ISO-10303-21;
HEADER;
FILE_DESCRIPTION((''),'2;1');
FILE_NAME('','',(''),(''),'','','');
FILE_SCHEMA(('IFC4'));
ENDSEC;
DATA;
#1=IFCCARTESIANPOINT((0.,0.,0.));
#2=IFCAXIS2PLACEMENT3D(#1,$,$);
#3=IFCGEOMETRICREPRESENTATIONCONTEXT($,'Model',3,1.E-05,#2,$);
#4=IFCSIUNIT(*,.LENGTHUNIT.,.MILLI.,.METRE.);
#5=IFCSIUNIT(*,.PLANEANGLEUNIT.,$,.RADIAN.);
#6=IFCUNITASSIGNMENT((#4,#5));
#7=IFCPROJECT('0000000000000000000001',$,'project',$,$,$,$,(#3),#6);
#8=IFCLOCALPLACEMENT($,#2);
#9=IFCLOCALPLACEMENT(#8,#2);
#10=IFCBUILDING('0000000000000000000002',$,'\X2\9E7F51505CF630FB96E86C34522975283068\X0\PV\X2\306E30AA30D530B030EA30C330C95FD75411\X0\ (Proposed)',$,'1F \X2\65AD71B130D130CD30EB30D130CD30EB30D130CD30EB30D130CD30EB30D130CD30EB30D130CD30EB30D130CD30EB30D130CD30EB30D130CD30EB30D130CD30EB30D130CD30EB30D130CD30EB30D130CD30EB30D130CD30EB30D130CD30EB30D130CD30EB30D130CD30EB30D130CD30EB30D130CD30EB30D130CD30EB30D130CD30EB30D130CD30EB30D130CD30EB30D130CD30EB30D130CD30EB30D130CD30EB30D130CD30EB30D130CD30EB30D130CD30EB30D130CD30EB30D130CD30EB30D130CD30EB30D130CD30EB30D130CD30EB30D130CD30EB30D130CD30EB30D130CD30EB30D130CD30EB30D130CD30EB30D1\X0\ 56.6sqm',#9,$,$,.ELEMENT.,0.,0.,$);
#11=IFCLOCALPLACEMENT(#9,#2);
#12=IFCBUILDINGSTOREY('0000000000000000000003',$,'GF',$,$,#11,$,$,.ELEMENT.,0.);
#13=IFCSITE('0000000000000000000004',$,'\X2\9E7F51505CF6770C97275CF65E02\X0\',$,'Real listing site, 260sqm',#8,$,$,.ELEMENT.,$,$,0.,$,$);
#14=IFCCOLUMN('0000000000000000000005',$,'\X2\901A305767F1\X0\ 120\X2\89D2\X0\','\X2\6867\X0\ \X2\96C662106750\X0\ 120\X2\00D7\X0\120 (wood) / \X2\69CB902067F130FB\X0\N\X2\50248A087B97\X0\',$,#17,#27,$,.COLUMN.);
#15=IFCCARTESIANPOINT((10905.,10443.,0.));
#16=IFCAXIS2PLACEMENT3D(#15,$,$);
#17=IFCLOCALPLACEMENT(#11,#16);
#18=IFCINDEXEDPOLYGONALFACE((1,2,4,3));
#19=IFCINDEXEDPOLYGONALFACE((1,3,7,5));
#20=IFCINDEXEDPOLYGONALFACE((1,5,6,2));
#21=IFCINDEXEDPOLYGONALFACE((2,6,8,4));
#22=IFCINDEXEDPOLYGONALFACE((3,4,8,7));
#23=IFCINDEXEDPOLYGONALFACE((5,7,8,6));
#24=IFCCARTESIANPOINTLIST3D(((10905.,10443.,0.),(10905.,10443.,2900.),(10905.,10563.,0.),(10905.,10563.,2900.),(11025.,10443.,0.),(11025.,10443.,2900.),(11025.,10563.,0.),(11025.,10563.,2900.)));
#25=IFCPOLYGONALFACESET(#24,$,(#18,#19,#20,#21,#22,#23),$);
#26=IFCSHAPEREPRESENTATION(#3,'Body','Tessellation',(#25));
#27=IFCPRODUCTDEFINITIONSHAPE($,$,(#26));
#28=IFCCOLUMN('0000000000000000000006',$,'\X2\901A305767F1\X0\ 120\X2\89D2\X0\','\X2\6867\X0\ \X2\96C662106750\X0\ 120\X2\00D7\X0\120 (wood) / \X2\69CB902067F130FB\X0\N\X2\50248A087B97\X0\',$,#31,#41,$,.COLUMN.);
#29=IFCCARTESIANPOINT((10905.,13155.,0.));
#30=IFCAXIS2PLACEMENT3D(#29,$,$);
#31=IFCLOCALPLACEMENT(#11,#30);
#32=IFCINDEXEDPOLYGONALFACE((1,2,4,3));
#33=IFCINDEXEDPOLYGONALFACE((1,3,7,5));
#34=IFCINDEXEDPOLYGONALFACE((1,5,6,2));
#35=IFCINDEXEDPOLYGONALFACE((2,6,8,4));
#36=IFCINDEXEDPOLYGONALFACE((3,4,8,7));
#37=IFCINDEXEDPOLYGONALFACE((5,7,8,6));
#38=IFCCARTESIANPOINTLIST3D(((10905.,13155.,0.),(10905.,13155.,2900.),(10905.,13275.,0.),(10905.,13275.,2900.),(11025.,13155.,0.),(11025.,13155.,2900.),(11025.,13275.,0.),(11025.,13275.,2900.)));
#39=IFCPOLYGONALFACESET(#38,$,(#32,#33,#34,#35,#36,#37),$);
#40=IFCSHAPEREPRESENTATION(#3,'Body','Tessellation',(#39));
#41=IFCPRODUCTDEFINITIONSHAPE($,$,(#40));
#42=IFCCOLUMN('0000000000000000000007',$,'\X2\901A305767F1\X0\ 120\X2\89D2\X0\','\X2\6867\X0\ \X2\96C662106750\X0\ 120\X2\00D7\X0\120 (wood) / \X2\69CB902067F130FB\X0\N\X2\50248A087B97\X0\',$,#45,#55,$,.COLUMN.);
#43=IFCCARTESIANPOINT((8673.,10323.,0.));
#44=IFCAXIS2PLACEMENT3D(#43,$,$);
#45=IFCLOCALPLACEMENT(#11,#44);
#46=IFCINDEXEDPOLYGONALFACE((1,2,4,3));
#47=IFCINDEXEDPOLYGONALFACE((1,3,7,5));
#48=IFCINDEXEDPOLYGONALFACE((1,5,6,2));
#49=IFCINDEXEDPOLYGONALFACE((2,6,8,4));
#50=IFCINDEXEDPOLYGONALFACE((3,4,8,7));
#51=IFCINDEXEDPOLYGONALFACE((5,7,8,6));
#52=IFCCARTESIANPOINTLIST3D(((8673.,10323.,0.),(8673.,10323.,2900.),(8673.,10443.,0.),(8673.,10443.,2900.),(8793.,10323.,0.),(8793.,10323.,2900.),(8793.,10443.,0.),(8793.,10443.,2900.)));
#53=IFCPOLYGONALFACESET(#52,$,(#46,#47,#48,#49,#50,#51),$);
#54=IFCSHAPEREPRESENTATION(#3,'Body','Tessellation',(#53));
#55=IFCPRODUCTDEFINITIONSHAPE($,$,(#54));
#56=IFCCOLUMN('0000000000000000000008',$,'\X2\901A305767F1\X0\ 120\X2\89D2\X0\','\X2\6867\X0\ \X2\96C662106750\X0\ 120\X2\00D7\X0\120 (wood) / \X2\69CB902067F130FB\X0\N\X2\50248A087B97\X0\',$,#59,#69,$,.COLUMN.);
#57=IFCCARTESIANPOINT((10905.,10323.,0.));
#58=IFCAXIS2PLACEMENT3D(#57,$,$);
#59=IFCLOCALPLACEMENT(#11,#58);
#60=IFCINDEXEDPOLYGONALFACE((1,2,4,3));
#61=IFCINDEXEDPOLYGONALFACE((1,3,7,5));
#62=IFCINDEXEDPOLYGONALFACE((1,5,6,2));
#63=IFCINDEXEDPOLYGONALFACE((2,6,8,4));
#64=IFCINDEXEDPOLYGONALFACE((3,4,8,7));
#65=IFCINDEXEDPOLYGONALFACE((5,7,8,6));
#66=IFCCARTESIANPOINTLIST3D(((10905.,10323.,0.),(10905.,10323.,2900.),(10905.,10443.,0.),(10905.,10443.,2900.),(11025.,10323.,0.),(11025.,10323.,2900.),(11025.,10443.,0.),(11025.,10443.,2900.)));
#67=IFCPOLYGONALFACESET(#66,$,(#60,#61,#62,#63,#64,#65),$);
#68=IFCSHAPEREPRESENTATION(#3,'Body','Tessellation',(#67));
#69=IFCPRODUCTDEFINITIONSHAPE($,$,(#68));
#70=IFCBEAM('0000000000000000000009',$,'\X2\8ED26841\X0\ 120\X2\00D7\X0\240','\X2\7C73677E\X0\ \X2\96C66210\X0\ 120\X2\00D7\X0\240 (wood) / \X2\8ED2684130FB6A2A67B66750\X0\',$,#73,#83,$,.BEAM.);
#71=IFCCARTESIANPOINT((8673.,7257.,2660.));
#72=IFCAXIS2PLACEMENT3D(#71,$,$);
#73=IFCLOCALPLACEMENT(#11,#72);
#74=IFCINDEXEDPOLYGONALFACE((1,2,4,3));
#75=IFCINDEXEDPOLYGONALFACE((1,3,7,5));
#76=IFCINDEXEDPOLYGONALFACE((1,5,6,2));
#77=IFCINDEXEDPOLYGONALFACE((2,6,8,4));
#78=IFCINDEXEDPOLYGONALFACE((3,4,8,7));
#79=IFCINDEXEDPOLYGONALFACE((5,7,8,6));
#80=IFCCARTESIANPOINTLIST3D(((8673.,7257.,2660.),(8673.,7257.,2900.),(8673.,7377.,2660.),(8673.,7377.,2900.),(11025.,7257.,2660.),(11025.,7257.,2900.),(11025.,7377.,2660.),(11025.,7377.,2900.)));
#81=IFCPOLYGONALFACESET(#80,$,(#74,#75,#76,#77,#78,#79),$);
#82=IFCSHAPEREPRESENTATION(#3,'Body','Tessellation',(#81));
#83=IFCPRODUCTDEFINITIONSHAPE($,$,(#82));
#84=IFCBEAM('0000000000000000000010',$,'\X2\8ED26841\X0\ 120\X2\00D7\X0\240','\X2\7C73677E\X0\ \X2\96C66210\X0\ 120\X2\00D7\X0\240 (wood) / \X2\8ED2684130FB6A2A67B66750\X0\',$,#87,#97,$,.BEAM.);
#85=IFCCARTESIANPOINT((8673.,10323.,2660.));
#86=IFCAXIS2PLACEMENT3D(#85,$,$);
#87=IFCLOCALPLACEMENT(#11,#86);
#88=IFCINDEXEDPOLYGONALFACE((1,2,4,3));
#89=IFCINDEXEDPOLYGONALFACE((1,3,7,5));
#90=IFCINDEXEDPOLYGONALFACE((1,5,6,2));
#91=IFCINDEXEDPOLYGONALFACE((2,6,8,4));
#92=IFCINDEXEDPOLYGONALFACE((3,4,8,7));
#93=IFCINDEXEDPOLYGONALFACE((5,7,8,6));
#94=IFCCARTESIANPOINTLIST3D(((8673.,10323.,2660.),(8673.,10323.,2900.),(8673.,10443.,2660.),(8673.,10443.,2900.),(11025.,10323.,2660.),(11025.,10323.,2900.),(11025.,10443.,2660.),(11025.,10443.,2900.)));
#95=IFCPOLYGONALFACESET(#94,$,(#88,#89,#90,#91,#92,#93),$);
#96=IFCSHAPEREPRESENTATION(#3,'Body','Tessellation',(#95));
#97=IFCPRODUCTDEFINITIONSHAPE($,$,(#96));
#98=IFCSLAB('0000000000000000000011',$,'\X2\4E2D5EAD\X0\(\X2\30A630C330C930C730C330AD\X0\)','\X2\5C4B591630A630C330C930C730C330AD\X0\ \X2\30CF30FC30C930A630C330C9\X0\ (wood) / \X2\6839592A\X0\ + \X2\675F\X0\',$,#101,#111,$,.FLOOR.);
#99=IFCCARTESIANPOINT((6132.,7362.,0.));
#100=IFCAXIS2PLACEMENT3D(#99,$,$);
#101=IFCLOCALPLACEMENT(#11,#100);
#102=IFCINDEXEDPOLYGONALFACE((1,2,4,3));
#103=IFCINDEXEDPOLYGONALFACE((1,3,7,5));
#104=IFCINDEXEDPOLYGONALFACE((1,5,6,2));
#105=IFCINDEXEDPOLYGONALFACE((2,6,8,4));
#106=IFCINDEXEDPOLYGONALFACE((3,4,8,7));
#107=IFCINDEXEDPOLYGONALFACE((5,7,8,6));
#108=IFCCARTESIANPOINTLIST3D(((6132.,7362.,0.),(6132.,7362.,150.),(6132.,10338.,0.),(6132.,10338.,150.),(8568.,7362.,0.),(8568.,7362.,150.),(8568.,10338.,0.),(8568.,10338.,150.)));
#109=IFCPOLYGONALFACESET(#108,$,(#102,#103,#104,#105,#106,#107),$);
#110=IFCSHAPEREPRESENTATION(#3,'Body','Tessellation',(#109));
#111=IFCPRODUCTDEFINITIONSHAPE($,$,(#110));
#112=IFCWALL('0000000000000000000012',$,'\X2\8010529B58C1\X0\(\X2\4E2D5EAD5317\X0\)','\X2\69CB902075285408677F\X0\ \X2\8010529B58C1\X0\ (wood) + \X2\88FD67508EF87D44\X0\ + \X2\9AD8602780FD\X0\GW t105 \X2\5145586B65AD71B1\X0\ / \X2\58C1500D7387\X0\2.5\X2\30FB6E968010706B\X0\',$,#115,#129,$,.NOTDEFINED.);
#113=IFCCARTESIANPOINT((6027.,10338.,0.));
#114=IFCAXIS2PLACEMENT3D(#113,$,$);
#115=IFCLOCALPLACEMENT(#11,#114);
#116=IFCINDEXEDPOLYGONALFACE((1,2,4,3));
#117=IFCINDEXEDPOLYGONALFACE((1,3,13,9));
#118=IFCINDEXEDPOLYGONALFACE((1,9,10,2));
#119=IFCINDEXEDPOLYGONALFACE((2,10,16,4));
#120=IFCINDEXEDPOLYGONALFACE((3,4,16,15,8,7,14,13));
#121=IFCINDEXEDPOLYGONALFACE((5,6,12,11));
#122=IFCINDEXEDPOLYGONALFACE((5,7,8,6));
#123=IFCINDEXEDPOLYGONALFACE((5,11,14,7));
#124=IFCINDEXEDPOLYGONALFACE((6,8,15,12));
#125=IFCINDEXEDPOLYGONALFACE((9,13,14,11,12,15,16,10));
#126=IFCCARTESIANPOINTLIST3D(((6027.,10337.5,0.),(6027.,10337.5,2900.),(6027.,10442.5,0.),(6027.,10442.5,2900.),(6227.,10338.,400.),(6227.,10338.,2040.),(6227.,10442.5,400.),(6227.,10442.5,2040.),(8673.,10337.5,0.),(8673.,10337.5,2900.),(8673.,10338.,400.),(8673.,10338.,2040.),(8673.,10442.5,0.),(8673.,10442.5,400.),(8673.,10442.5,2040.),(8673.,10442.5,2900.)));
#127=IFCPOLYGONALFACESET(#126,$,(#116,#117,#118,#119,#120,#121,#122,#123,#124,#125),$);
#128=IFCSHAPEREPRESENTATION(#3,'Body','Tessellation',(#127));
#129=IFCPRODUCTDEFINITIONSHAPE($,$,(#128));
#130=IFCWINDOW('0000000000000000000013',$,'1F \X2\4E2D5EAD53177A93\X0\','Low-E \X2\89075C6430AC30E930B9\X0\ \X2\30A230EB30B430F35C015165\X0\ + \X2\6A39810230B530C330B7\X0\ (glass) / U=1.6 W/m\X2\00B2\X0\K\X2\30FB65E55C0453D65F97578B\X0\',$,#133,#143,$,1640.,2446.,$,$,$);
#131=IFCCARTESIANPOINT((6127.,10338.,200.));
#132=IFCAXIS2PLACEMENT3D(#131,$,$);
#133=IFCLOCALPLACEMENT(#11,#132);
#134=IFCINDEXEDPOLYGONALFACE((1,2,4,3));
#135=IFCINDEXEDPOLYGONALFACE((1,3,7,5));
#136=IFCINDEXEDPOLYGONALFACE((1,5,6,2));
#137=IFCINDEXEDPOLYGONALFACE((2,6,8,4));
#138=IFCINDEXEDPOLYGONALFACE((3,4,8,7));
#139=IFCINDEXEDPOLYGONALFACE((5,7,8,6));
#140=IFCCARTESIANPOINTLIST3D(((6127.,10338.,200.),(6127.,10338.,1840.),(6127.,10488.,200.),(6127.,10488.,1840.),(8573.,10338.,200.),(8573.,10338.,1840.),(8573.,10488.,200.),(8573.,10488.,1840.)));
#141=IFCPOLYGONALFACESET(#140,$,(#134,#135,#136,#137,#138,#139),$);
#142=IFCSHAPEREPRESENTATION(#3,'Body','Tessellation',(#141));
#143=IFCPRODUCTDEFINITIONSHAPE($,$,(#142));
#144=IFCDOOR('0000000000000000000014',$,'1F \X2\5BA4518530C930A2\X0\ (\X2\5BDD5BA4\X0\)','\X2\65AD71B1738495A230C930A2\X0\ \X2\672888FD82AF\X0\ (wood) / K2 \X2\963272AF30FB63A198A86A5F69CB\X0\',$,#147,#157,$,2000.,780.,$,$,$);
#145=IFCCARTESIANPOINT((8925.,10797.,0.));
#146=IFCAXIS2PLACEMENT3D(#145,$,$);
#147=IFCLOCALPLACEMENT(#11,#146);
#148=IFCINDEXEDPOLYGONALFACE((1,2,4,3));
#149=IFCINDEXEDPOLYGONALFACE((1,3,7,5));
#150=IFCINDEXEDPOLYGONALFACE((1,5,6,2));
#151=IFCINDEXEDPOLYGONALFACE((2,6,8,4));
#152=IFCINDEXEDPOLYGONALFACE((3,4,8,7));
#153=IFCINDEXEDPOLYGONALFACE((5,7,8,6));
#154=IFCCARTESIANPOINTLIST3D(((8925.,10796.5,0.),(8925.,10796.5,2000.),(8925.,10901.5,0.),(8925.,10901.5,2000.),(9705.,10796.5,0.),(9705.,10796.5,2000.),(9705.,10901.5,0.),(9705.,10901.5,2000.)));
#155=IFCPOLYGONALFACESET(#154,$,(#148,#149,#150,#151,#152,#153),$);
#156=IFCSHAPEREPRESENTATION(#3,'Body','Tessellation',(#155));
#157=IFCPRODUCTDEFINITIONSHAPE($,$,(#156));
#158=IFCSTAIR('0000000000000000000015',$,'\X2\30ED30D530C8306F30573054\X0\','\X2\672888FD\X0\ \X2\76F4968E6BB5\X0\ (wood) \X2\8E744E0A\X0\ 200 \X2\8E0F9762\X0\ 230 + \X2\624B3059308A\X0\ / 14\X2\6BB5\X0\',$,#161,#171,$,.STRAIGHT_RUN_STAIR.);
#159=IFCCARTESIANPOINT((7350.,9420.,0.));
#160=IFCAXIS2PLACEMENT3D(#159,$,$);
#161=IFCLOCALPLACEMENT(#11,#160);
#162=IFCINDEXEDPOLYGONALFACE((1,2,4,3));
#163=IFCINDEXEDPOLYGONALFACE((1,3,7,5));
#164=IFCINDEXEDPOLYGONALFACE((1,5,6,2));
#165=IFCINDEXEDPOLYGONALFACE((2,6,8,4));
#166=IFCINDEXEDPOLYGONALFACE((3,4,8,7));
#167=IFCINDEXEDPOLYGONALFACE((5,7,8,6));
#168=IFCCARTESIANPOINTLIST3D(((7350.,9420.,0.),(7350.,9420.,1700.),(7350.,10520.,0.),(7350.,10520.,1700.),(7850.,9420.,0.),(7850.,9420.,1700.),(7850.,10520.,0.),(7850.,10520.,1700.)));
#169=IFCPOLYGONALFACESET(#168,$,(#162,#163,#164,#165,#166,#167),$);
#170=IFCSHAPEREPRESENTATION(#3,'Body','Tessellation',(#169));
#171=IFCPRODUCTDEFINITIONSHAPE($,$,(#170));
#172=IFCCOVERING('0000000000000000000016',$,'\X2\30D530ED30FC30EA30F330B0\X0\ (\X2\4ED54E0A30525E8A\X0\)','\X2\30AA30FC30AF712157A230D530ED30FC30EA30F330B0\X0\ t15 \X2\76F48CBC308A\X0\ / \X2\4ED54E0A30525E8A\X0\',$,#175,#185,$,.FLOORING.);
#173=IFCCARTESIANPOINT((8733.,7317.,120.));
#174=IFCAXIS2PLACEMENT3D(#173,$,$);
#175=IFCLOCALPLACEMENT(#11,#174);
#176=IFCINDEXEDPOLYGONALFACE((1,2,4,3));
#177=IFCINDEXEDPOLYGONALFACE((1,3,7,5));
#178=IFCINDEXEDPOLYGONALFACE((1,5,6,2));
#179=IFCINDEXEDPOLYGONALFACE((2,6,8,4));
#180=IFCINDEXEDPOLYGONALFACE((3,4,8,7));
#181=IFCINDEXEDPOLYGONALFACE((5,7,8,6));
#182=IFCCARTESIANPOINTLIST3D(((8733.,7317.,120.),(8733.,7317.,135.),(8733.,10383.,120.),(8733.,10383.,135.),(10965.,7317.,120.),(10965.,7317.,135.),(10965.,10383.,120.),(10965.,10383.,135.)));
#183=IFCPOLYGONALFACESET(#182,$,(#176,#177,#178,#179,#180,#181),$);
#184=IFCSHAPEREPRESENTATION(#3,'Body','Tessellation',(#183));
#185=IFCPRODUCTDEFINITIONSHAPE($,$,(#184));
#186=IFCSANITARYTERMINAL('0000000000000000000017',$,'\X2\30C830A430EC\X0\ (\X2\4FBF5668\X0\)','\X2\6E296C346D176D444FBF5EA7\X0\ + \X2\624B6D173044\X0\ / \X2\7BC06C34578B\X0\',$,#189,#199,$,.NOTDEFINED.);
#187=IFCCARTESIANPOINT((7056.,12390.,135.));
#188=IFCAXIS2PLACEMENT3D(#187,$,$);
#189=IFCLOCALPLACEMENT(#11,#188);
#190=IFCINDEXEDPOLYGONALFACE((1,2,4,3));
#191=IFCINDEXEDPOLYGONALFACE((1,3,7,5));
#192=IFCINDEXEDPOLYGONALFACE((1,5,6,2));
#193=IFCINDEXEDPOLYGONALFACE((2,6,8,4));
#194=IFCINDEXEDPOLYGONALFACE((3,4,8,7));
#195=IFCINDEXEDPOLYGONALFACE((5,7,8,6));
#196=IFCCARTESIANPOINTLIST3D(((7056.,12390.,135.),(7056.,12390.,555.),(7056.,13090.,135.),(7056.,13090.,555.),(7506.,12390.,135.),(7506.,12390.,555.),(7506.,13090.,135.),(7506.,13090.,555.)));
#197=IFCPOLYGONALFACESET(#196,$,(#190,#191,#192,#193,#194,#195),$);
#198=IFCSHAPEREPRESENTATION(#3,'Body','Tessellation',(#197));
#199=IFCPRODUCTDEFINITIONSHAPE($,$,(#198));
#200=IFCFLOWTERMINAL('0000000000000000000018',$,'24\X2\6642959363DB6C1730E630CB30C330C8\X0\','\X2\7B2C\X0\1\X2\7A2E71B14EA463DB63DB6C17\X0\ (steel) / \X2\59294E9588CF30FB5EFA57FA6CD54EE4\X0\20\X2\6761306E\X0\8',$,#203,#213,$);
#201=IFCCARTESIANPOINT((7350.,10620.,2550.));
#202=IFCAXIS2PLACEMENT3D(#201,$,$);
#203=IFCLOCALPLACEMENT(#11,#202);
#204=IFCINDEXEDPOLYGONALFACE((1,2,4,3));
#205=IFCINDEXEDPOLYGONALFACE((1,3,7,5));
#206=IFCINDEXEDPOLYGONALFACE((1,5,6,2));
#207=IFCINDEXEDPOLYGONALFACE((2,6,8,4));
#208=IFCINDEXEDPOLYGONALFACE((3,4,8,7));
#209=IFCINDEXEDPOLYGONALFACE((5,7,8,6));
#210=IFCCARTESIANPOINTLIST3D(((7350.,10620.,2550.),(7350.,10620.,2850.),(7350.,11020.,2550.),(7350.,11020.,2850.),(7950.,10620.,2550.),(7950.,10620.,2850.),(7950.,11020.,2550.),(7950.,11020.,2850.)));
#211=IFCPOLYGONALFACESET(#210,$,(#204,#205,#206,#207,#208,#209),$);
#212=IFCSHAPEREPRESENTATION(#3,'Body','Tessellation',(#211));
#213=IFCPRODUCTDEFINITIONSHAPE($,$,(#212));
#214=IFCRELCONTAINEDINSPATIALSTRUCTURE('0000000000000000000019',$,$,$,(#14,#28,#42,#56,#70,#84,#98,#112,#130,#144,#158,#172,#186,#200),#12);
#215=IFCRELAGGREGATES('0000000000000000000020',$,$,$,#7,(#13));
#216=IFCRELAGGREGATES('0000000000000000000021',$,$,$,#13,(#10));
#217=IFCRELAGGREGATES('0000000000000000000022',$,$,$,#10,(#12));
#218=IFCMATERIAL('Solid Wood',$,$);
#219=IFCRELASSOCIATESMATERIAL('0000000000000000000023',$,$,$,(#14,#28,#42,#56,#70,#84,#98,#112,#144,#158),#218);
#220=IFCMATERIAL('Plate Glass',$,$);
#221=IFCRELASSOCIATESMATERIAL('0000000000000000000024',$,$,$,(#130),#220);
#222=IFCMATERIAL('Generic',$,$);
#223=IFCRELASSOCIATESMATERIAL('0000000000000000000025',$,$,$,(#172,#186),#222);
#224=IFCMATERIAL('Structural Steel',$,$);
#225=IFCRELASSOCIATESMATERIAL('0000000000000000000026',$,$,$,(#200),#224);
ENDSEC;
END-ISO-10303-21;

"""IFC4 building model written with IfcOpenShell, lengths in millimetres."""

from ifc_helpers import new_model, si_unit, frame, frame_2d, origin, place, context, project, spatial, rectangle, extrude, material, element, fill, save


model = new_model("IFC4")

# Units and contexts
model_context = context("Model", 3, precision=1e-05, world=origin())
ifc_project = project(units=[si_unit("LENGTHUNIT", "METRE", prefix="MILLI"), si_unit("PLANEANGLEUNIT", "RADIAN")], contexts=[model_context])

# Site, building, storey
site_placement = place(None, origin())
site = spatial("IfcSite", under=ifc_project, at=site_placement, Name="鹿児島県霧島市", ObjectType="Real listing site, 260sqm", CompositionType="ELEMENT", RefElevation=0.0)
building_placement = place(site_placement, origin())
building = spatial("IfcBuilding", under=site, at=building_placement, Name="鹿児島・雨水利用とPVのオフグリッド志向 (Proposed)", ObjectType="1F 断熱パネルパネルパネルパネルパネルパネルパネルパネルパネルパネルパネルパネルパネルパネルパネルパネルパネルパネルパネルパネルパネルパネルパネルパネルパネルパネルパネルパネルパネルパネルパネルパネルパネルパネルパネルパネルパネルパネルパネルパ 56.6sqm", CompositionType="ELEMENT", ElevationOfRefHeight=0.0, ElevationOfTerrain=0.0)
storey_placement = place(building_placement, origin())
storey = spatial("IfcBuildingStorey", under=building, at=storey_placement, Name="GF", CompositionType="ELEMENT", Elevation=0.0)

# Columns
ifc_material_1 = material(Name="Solid Wood")
column_1_placement = place(storey_placement, frame((10905.0, 10443.0, 0.0)))
element("IfcColumn", 1, at=column_1_placement, inside=storey, material=ifc_material_1, Name="通し柱 120角", Description="桧 集成材 120×120 (wood) / 構造柱・N値計算", PredefinedType="COLUMN", context=model_context, shape_type="SweptSolid", body=[
    extrude(rectangle(XDim=120.0, YDim=120.0, at=frame_2d((60.0, 60.0))), frame((10905.0, 10443.0, 0.0)), (0.0, 0.0, 1.0), 2900.0),
])
column_2_placement = place(storey_placement, frame((10905.0, 13155.0, 0.0)))
element("IfcColumn", 2, at=column_2_placement, inside=storey, material=ifc_material_1, Name="通し柱 120角", Description="桧 集成材 120×120 (wood) / 構造柱・N値計算", PredefinedType="COLUMN", context=model_context, shape_type="SweptSolid", body=[
    extrude(rectangle(XDim=120.0, YDim=120.0, at=frame_2d((60.0, 60.0))), frame((10905.0, 13155.0, 0.0)), (0.0, 0.0, 1.0), 2900.0),
])
column_3_placement = place(storey_placement, frame((8673.0, 10323.0, 0.0)))
element("IfcColumn", 3, at=column_3_placement, inside=storey, material=ifc_material_1, Name="通し柱 120角", Description="桧 集成材 120×120 (wood) / 構造柱・N値計算", PredefinedType="COLUMN", context=model_context, shape_type="SweptSolid", body=[
    extrude(rectangle(XDim=120.0, YDim=120.0, at=frame_2d((60.0, 60.0))), frame((8673.0, 10323.0, 0.0)), (0.0, 0.0, 1.0), 2900.0),
])
column_4_placement = place(storey_placement, frame((10905.0, 10323.0, 0.0)))
element("IfcColumn", 4, at=column_4_placement, inside=storey, material=ifc_material_1, Name="通し柱 120角", Description="桧 集成材 120×120 (wood) / 構造柱・N値計算", PredefinedType="COLUMN", context=model_context, shape_type="SweptSolid", body=[
    extrude(rectangle(XDim=120.0, YDim=120.0, at=frame_2d((60.0, 60.0))), frame((10905.0, 10323.0, 0.0)), (0.0, 0.0, 1.0), 2900.0),
])

# Beams
beam_1_placement = place(storey_placement, frame((8673.0, 7257.0, 2660.0)))
element("IfcBeam", 5, at=beam_1_placement, inside=storey, material=ifc_material_1, Name="軒桁 120×240", Description="米松 集成 120×240 (wood) / 軒桁・横架材", PredefinedType="BEAM", context=model_context, shape_type="SweptSolid", body=[
    extrude(rectangle(XDim=2352.0, YDim=120.0, at=frame_2d((1176.0, 60.0))), frame((8673.0, 7257.0, 2660.0)), (0.0, 0.0, 1.0), 240.0),
])
beam_2_placement = place(storey_placement, frame((8673.0, 10323.0, 2660.0)))
element("IfcBeam", 6, at=beam_2_placement, inside=storey, material=ifc_material_1, Name="軒桁 120×240", Description="米松 集成 120×240 (wood) / 軒桁・横架材", PredefinedType="BEAM", context=model_context, shape_type="SweptSolid", body=[
    extrude(rectangle(XDim=2352.0, YDim=120.0, at=frame_2d((1176.0, 60.0))), frame((8673.0, 10323.0, 2660.0)), (0.0, 0.0, 1.0), 240.0),
])

# Slab
slab_placement = place(storey_placement, frame((6132.0, 7362.0, 0.0)))
element("IfcSlab", 7, at=slab_placement, inside=storey, material=ifc_material_1, Name="中庭(ウッドデッキ)", Description="屋外ウッドデッキ ハードウッド (wood) / 根太 + 束", PredefinedType="FLOOR", context=model_context, shape_type="SweptSolid", body=[
    extrude(rectangle(XDim=2436.0, YDim=2976.0, at=frame_2d((1218.0, 1488.0))), frame((6132.0, 7362.0, 0.0)), (0.0, 0.0, 1.0), 150.0),
])

# Wall, opening, window
wall_1_placement = place(storey_placement, frame((6027.0, 10338.0, 0.0)))
wall_1 = element("IfcWall", 8, at=wall_1_placement, inside=storey, material=ifc_material_1, Name="耐力壁(中庭北)", Description="構造用合板 耐力壁 (wood) + 製材軸組 + 高性能GW t105 充填断熱 / 壁倍率2.5・準耐火", PredefinedType="NOTDEFINED", context=model_context, shape_type="SweptSolid", body=[
    extrude(rectangle(XDim=2646.0, YDim=105.0, at=frame_2d((1323.0, 52.0))), frame((6027.0, 10338.0, 0.0)), (0.0, 0.0, 1.0), 2900.0),
])
opening_placement = place(storey_placement, frame((6127.0, 10338.0, 200.0)))
opening = element("IfcOpeningElement", 9, at=opening_placement, cuts=wall_1, PredefinedType="NOTDEFINED", context=model_context, shape_type="SweptSolid", body=[
    extrude(rectangle(XDim=2446.0, YDim=150.0, at=frame_2d((1223.0, 75.0))), frame((6127.0, 10338.0, 200.0)), (0.0, 0.0, 1.0), 1640.0),
])
ifc_material_2 = material(Name="Plate Glass")
window_placement = place(storey_placement, frame((6127.0, 10338.0, 200.0)))
window = element("IfcWindow", 10, at=window_placement, inside=storey, material=ifc_material_2, Name="1F 中庭北窓", Description="Low-E 複層ガラス アルゴン封入 + 樹脂サッシ (glass) / U=1.6 W/m²K・日射取得型", OverallHeight=1640.0, OverallWidth=2446.0, context=model_context, shape_type="SweptSolid", body=[
    extrude(rectangle(XDim=2446.0, YDim=150.0, at=frame_2d((1223.0, 75.0))), frame((6127.0, 10338.0, 200.0)), (0.0, 0.0, 1.0), 1640.0),
])
fill(opening, window)

# Door
door_placement = place(storey_placement, frame((8925.0, 10797.0, 0.0)))
element("IfcDoor", 11, at=door_placement, inside=storey, material=ifc_material_1, Name="1F 室内ドア (寝室)", Description="断熱玄関ドア 木製芯 (wood) / K2 防犯・採風機構", OverallHeight=2000.0, OverallWidth=780.0, context=model_context, shape_type="SweptSolid", body=[
    extrude(rectangle(XDim=780.0, YDim=105.0, at=frame_2d((390.0, 52.0))), frame((8925.0, 10797.0, 0.0)), (0.0, 0.0, 1.0), 2000.0),
])

# Stair
stair_placement = place(storey_placement, frame((7350.0, 9420.0, 0.0)))
element("IfcStair", 12, at=stair_placement, inside=storey, material=ifc_material_1, Name="ロフトはしご", Description="木製 直階段 (wood) 蹴上 200 踏面 230 + 手すり / 14段", PredefinedType="STRAIGHT_RUN_STAIR", context=model_context, shape_type="SweptSolid", body=[
    extrude(rectangle(XDim=500.0, YDim=1100.0, at=frame_2d((250.0, 550.0))), frame((7350.0, 9420.0, 0.0)), (0.0, 0.0, 1.0), 1700.0),
])

# Covering
ifc_material_3 = material(Name="Generic")
covering_placement = place(storey_placement, frame((8733.0, 7317.0, 120.0)))
element("IfcCovering", 13, at=covering_placement, inside=storey, material=ifc_material_3, Name="フローリング (仕上げ床)", Description="オーク無垢フローリング t15 直貼り / 仕上げ床", PredefinedType="FLOORING", context=model_context, shape_type="SweptSolid", body=[
    extrude(rectangle(XDim=2232.0, YDim=3066.0, at=frame_2d((1116.0, 1533.0))), frame((8733.0, 7317.0, 120.0)), (0.0, 0.0, 1.0), 15.0),
])

# Sanitary terminal
sanitary_terminal_placement = place(storey_placement, frame((7056.0, 12390.0, 135.0)))
element("IfcSanitaryTerminal", 14, at=sanitary_terminal_placement, inside=storey, material=ifc_material_3, Name="トイレ (便器)", Description="温水洗浄便座 + 手洗い / 節水型", PredefinedType="NOTDEFINED", context=model_context, shape_type="SweptSolid", body=[
    extrude(rectangle(XDim=450.0, YDim=700.0, at=frame_2d((225.0, 350.0))), frame((7056.0, 12390.0, 135.0)), (0.0, 0.0, 1.0), 420.0),
])

# Flow terminal
ifc_material_4 = material(Name="Structural Steel")
flow_terminal_placement = place(storey_placement, frame((7350.0, 10620.0, 2550.0)))
element("IfcFlowTerminal", 15, at=flow_terminal_placement, inside=storey, material=ifc_material_4, Name="24時間換気ユニット", Description="第1種熱交換換気 (steel) / 天井裏・建基法令20条の8", context=model_context, shape_type="SweptSolid", body=[
    extrude(rectangle(XDim=600.0, YDim=400.0, at=frame_2d((300.0, 200.0))), frame((7350.0, 10620.0, 2550.0)), (0.0, 0.0, 1.0), 300.0),
])

save(model, "model.ifc")
